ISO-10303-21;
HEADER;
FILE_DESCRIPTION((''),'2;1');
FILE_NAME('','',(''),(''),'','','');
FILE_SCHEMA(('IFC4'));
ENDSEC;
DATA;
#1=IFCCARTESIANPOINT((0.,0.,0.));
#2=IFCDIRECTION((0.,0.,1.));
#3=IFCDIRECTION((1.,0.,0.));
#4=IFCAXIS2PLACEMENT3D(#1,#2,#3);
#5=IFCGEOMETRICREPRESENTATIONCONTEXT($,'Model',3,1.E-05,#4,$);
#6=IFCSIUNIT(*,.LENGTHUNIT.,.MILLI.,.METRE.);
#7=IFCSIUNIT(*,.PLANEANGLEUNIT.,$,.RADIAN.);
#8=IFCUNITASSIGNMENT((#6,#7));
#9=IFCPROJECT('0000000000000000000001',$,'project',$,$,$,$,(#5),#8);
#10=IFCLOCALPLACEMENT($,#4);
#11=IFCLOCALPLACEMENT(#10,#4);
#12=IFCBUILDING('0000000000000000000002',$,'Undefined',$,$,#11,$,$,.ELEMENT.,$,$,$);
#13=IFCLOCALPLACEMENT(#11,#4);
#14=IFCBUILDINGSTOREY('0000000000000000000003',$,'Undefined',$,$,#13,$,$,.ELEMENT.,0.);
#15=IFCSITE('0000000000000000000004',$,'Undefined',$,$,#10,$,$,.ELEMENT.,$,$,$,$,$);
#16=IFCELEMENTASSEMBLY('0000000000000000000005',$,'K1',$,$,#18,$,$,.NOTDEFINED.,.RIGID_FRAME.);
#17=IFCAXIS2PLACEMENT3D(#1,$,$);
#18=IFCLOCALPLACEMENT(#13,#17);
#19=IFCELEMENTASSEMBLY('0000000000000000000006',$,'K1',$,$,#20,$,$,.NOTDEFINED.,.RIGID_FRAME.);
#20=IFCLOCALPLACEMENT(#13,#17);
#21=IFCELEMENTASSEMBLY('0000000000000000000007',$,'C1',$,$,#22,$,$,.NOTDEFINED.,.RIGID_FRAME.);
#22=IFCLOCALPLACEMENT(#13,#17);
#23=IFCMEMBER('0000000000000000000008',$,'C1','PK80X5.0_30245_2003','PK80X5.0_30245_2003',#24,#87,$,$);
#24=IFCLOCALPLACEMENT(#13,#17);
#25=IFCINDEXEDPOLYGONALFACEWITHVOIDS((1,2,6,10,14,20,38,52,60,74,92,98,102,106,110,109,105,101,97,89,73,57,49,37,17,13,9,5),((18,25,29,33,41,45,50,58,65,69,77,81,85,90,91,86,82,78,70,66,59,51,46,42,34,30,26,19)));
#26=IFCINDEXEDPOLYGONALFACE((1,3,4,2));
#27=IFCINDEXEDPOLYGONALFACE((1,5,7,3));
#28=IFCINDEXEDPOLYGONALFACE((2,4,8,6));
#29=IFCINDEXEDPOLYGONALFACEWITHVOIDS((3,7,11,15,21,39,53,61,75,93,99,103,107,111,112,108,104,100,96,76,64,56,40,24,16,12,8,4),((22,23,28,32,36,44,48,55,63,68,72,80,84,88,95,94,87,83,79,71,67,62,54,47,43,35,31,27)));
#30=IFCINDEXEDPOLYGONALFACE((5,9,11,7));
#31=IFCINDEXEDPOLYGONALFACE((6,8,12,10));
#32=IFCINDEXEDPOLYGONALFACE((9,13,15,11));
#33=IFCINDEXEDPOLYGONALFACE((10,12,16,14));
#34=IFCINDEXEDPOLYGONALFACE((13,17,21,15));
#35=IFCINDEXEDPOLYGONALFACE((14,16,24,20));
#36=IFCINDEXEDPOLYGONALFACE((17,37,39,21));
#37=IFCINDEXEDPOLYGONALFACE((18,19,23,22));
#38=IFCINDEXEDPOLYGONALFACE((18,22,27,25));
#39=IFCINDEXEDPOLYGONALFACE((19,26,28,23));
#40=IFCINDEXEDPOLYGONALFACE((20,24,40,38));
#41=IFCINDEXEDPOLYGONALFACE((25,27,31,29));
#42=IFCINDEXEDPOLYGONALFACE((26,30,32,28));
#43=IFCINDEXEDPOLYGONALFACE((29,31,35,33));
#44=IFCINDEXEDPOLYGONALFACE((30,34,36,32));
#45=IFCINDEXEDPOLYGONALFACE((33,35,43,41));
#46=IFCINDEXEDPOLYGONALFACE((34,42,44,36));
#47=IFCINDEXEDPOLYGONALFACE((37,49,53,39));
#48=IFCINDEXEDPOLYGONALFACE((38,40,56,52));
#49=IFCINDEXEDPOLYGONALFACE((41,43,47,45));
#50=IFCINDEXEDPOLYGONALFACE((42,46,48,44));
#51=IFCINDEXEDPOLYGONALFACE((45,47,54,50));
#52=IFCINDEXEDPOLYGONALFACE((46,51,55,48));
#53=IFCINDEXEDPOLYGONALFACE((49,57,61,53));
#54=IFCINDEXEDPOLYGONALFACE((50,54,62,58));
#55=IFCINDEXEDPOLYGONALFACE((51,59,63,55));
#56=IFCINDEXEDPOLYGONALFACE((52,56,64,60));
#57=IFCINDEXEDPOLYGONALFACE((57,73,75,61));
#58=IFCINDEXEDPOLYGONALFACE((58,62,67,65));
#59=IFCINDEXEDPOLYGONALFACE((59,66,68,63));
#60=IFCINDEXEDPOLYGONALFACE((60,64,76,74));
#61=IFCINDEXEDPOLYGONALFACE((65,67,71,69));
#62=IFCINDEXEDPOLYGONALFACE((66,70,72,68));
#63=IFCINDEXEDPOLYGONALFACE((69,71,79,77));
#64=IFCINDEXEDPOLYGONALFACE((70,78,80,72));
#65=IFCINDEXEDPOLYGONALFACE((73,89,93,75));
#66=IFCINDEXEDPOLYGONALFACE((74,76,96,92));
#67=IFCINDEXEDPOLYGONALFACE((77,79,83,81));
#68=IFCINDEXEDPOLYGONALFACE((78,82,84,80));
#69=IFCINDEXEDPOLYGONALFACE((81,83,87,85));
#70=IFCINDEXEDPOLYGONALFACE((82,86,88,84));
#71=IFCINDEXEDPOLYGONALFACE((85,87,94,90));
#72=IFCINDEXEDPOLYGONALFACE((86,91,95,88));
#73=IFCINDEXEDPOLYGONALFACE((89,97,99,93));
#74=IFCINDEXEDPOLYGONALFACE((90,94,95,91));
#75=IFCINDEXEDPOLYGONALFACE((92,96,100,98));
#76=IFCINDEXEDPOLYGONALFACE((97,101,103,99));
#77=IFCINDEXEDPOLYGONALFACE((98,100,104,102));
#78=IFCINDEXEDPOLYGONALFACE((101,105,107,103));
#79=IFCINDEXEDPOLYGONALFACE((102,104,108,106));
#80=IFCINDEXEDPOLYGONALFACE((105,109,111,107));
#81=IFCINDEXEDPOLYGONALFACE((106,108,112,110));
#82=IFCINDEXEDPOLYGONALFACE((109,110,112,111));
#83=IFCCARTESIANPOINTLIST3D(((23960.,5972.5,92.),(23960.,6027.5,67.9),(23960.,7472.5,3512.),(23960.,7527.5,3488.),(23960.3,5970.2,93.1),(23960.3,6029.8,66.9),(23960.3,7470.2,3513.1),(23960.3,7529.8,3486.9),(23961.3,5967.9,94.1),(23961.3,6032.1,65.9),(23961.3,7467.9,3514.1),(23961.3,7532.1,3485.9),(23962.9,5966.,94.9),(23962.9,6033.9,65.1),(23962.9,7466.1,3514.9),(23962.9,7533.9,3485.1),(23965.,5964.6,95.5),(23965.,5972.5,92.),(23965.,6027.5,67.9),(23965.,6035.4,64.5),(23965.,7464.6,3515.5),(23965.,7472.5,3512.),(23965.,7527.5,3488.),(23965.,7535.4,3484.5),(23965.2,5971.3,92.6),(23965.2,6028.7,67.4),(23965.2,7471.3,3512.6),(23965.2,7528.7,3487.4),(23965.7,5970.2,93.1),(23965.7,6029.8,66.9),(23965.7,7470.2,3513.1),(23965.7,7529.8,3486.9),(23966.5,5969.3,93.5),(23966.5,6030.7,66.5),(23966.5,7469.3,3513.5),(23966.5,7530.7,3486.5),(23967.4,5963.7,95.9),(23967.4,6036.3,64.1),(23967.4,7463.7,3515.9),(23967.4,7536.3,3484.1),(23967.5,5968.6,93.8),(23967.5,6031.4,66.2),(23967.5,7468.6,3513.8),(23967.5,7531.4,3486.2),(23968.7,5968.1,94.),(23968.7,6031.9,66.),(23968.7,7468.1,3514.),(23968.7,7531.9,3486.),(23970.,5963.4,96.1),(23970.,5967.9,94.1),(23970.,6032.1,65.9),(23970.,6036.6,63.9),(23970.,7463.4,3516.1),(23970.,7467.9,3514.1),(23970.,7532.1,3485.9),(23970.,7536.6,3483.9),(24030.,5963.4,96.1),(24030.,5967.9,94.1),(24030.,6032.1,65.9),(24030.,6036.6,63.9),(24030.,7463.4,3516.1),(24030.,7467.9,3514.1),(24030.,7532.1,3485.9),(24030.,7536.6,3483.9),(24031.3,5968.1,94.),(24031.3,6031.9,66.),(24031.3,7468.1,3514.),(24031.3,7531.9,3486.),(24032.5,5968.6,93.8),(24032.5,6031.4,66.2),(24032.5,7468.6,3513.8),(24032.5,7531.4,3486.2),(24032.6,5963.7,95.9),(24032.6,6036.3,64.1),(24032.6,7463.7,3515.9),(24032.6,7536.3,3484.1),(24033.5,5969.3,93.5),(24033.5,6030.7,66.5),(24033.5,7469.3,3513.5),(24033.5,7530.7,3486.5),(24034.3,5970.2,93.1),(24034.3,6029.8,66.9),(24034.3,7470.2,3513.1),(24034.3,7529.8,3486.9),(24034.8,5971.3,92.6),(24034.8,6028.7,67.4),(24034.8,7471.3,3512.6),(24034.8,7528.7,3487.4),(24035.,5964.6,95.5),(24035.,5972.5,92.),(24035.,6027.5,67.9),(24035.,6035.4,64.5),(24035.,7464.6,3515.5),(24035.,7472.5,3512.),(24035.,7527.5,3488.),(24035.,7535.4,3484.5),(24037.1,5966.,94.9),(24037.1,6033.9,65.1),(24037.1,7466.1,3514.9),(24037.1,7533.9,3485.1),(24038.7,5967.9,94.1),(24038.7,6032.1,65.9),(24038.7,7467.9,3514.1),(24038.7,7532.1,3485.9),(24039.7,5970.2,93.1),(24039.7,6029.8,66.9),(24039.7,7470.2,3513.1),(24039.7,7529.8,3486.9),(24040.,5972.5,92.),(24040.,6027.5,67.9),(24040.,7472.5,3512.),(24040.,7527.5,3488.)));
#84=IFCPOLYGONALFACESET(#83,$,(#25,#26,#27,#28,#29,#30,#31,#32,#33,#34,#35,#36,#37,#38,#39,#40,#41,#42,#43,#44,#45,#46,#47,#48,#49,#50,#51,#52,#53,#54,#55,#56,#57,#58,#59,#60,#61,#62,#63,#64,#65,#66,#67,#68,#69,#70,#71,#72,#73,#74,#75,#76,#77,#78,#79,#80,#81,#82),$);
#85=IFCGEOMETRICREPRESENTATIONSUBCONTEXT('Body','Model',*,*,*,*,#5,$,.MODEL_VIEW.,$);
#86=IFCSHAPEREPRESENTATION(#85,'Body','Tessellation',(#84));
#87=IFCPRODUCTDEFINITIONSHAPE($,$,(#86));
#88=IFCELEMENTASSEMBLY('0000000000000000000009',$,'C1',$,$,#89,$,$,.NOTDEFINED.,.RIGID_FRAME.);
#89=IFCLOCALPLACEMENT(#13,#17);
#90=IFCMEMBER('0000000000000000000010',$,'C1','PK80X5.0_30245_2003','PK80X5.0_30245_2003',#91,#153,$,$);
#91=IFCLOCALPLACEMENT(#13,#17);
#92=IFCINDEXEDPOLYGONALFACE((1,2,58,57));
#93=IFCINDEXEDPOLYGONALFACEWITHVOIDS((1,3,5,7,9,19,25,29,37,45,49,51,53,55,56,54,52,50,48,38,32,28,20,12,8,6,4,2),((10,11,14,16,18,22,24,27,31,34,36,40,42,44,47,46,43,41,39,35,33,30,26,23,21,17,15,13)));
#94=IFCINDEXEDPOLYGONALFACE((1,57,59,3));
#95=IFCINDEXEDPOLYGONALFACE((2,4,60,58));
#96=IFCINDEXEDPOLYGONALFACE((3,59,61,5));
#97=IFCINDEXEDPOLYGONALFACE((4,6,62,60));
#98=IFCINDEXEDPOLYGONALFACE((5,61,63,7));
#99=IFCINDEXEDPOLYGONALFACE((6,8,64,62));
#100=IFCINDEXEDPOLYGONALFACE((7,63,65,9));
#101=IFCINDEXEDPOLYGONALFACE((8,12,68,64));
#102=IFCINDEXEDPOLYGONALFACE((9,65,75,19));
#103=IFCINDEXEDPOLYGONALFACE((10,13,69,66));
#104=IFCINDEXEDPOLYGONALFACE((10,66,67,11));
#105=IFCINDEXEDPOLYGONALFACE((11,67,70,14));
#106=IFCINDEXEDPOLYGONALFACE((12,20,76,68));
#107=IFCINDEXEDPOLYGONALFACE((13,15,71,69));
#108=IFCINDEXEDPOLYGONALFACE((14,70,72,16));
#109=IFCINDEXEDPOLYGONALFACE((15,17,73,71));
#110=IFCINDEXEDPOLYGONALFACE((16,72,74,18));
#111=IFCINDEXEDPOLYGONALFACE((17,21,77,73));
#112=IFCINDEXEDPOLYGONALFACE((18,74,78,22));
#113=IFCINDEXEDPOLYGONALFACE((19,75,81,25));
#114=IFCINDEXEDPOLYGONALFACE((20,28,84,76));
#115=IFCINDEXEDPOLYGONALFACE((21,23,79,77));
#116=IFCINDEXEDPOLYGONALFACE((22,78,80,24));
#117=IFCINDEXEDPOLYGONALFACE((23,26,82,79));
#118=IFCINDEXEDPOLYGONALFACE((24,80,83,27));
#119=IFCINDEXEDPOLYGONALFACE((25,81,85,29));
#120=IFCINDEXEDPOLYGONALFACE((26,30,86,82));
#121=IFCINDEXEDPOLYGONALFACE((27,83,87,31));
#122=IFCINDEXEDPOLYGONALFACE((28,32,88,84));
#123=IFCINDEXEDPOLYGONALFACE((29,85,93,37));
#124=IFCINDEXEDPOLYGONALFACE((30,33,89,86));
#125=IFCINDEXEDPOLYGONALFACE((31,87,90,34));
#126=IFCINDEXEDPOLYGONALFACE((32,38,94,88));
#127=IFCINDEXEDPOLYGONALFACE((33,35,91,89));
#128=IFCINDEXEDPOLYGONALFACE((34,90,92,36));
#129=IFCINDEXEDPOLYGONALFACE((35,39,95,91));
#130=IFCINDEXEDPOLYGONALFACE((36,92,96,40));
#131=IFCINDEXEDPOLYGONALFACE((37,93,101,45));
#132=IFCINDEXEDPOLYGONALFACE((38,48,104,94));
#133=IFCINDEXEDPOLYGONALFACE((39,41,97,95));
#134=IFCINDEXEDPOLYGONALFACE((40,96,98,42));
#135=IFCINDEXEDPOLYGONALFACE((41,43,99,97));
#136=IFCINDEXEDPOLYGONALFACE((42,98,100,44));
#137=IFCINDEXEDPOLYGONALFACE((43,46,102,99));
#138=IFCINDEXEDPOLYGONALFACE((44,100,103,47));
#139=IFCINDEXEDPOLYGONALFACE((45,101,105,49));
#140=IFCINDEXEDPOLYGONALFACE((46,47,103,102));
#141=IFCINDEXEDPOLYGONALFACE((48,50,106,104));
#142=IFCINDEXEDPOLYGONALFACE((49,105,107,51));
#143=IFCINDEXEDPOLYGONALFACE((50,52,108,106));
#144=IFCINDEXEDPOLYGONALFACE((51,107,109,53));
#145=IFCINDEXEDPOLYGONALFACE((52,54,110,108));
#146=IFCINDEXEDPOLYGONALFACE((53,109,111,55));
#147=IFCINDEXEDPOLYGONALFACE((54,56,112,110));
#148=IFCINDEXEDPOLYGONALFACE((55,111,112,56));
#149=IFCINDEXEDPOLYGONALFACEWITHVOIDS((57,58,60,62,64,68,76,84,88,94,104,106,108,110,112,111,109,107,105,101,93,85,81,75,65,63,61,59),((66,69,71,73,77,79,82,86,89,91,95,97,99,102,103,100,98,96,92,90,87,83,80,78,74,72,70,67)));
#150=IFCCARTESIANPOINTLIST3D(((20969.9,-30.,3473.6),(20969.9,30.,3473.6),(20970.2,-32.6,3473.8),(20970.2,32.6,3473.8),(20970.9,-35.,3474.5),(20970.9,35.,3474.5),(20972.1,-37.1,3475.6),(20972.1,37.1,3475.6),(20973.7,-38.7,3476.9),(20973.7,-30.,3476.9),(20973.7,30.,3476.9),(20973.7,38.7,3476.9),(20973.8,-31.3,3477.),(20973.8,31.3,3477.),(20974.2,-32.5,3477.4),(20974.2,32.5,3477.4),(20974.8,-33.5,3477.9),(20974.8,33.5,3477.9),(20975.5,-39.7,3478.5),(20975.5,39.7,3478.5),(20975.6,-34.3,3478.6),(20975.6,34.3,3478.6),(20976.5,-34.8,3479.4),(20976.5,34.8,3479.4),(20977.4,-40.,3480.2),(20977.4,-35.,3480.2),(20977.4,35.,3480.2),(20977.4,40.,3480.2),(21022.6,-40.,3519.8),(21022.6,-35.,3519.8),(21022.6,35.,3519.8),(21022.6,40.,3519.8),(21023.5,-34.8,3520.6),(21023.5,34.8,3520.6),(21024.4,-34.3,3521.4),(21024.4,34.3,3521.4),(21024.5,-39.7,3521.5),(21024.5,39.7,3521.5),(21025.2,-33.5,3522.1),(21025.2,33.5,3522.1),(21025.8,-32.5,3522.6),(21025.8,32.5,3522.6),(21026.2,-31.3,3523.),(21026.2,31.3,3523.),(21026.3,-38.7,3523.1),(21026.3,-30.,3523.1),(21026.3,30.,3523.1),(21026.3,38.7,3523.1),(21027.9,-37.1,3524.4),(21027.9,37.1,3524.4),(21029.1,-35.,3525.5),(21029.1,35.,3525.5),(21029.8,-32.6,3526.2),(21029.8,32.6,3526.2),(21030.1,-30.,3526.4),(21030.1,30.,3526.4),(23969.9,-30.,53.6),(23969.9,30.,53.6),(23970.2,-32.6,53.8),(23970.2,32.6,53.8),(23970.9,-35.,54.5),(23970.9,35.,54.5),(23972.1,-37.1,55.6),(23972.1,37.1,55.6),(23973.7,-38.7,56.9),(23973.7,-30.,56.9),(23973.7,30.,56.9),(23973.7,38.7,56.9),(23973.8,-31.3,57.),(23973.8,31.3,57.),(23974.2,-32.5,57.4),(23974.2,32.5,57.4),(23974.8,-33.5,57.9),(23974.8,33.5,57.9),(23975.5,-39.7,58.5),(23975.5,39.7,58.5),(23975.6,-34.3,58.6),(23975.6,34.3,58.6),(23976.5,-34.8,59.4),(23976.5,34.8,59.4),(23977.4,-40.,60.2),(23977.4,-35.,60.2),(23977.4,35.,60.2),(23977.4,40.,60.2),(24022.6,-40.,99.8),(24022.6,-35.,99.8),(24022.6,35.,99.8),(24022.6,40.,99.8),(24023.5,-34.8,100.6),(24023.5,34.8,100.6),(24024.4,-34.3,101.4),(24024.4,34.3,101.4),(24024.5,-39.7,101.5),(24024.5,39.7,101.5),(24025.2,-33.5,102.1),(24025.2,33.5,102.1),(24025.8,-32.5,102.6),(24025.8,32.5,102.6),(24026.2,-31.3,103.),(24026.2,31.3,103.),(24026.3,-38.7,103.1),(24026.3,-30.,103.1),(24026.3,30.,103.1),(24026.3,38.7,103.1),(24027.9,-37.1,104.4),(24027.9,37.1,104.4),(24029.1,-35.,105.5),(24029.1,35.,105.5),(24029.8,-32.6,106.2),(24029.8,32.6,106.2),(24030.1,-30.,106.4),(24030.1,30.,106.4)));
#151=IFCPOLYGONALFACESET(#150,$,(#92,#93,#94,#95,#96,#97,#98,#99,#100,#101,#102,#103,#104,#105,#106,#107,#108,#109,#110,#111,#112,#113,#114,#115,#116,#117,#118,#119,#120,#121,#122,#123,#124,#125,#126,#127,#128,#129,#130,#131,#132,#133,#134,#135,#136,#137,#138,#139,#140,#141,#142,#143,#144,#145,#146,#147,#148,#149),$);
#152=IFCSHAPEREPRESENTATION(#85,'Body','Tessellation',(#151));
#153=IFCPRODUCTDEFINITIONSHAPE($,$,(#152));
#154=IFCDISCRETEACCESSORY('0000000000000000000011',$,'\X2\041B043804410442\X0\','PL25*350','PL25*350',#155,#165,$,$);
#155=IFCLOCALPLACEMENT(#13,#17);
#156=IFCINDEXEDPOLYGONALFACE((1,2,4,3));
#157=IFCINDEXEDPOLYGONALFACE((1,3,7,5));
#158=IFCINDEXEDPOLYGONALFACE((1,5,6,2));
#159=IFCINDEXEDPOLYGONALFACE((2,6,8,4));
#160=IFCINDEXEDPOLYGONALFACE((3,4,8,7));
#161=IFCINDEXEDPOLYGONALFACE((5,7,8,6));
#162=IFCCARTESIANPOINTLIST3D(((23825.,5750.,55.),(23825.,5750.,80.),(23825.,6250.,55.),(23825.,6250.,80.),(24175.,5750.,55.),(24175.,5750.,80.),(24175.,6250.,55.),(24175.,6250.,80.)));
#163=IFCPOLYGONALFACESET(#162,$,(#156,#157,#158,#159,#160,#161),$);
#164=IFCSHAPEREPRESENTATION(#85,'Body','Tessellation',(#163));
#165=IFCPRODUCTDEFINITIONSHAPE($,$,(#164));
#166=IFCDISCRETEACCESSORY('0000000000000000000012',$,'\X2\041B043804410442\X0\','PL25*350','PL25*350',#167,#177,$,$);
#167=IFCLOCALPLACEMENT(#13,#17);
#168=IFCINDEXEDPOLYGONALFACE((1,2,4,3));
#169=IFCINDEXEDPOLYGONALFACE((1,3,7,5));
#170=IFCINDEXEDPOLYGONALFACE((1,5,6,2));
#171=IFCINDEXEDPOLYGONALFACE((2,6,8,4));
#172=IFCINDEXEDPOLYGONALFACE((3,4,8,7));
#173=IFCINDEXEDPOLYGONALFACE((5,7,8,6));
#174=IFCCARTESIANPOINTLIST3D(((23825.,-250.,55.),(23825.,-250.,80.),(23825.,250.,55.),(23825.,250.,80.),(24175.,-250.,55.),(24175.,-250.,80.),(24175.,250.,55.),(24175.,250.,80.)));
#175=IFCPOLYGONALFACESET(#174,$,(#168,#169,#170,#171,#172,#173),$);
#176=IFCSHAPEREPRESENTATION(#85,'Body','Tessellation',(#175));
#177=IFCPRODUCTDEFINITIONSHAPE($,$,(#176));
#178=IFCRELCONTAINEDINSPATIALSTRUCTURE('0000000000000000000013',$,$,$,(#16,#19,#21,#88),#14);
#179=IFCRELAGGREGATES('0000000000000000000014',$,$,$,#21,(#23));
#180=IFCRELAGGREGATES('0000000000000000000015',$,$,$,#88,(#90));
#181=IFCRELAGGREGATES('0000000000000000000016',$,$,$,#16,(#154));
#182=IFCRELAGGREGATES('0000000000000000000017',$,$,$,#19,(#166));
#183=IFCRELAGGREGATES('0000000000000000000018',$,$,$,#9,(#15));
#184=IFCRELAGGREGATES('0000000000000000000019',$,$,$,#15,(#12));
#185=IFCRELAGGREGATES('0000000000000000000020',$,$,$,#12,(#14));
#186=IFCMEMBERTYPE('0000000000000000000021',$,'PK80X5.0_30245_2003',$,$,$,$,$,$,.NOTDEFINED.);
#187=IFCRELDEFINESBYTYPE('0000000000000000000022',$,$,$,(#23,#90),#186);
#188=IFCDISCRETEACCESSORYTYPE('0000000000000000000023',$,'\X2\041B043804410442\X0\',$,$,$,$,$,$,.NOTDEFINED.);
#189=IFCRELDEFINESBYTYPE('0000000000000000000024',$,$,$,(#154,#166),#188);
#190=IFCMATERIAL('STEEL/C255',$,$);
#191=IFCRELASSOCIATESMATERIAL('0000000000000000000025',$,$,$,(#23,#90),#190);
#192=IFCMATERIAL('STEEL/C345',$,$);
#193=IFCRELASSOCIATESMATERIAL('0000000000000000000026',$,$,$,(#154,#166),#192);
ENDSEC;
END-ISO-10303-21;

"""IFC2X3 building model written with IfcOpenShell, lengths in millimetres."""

from ifc_helpers import new_model, si_unit, frame, origin_with_axes, origin_2d_with_axis, place, context, subcontext, project, spatial, polyline, hollow_rectangle, outline, extrude, material, type_object, element, aggregate, save


model = new_model("IFC2X3")

# Units and contexts
model_context = context("Model", 3, precision=1e-05, world=origin_with_axes())
body_context = subcontext(model_context, "Body", "Model", "MODEL_VIEW")
ifc_project = project(units=[si_unit("LENGTHUNIT", "METRE", prefix="MILLI"), si_unit("PLANEANGLEUNIT", "RADIAN")], contexts=[model_context])

# Site, building, storey
site_placement = place(None, origin_with_axes())
site = spatial("IfcSite", under=ifc_project, at=site_placement, Name="Undefined", CompositionType="ELEMENT")
building_placement = place(site_placement, origin_with_axes())
building = spatial("IfcBuilding", under=site, at=building_placement, Name="Undefined", CompositionType="ELEMENT")
storey_placement = place(building_placement, origin_with_axes())
storey = spatial("IfcBuildingStorey", under=building, at=storey_placement, Name="Undefined", CompositionType="ELEMENT", Elevation=0.0)

# Element assemblies
assembly_1_placement = place(storey_placement, origin_with_axes())
assembly_1 = element("IfcElementAssembly", 1, at=assembly_1_placement, inside=storey, Name="K1", AssemblyPlace="NOTDEFINED", PredefinedType="RIGID_FRAME")
ifc_material_1 = material(Name="STEEL/C345")
assembly_2_placement = place(storey_placement, origin_with_axes())
assembly_2 = element("IfcElementAssembly", 2, at=assembly_2_placement, inside=storey, Name="K1", AssemblyPlace="NOTDEFINED", PredefinedType="RIGID_FRAME")

# Shared definitions
ifc_material_2 = material(Name="STEEL/C255")

# Element assemblies, members
assembly_3_placement = place(storey_placement, origin_with_axes())
assembly_3 = element("IfcElementAssembly", 3, at=assembly_3_placement, inside=storey, Name="C1", AssemblyPlace="NOTDEFINED", PredefinedType="RIGID_FRAME")
member_type = type_object("IfcMemberType", Name="PK80X5.0_30245_2003", PredefinedType="NOTDEFINED")
member_1_placement = place(assembly_3_placement, frame((24000.0, 6000.0, 80.0), z_axis=(0.0, 0.915788, -0.401661), x_axis=(0.0, 0.401661, 0.915788)))
member_1 = element("IfcMember", 4, at=member_1_placement, type_object=member_type, material=ifc_material_2, Name="C1", Description="PK80X5.0_30245_2003", ObjectType="PK80X5.0_30245_2003", context=body_context, shape_type="SweptSolid", body=[
    extrude(hollow_rectangle(XDim=80.0, YDim=80.0, WallThickness=5.0, InnerFilletRadius=5.0, OuterFilletRadius=10.0, at=origin_2d_with_axis()), frame((3734.5, 0.0, 0.0), z_axis=(-1.0, 0.0, 0.0), x_axis=(0.0, -1.0, 0.0)), (0.0, 0.0, 1.0), 3734.5),
])
aggregate(assembly_3, [member_1])
assembly_4_placement = place(storey_placement, origin_with_axes())
assembly_4 = element("IfcElementAssembly", 5, at=assembly_4_placement, inside=storey, Name="C1", AssemblyPlace="NOTDEFINED", PredefinedType="RIGID_FRAME")
member_2_placement = place(assembly_4_placement, frame((24000.0, 0.0, 80.0), z_axis=(-0.751759, 0.0, -0.659438), x_axis=(-0.659438, 0.0, 0.751759)))
member_2 = element("IfcMember", 6, at=member_2_placement, type_object=member_type, material=ifc_material_2, Name="C1", Description="PK80X5.0_30245_2003", ObjectType="PK80X5.0_30245_2003", context=body_context, shape_type="SweptSolid", body=[
    extrude(hollow_rectangle(XDim=80.0, YDim=80.0, WallThickness=5.0, InnerFilletRadius=5.0, OuterFilletRadius=10.0, at=origin_2d_with_axis()), frame((4549.3, 0.0, 0.0), z_axis=(-1.0, 0.0, 0.0), x_axis=(0.0, -1.0, 0.0)), (0.0, 0.0, 1.0), 4549.3),
])
aggregate(assembly_4, [member_2])

# Discrete accessories
discrete_accessory_type = type_object("IfcDiscreteAccessoryType", Name="Лист")
discrete_accessory_1_placement = place(assembly_1_placement, frame((23825.0, 6250.0, 67.5), z_axis=(0.0, 0.0, 1.0), x_axis=(0.0, -1.0, 0.0)))
discrete_accessory_1 = element("IfcDiscreteAccessory", 7, at=discrete_accessory_1_placement, type_object=discrete_accessory_type, material=ifc_material_1, Name="Лист", Description="PL25*350", ObjectType="PL25*350", context=body_context, shape_type="SweptSolid", body=[
    extrude(outline(polyline([(0.0, 0.0), (500.0, 0.0), (500.0, 350.0), (0.0, 350.0), (0.0, 0.0)])), frame((0.0, 0.0, -12.5), z_axis=(0.0, 0.0, 1.0), x_axis=(1.0, 0.0, 0.0)), (0.0, 0.0, 1.0), 25.0),
])
aggregate(assembly_1, [discrete_accessory_1])
discrete_accessory_2_placement = place(assembly_2_placement, frame((23825.0, 250.0, 67.5), z_axis=(0.0, 0.0, 1.0), x_axis=(0.0, -1.0, 0.0)))
discrete_accessory_2 = element("IfcDiscreteAccessory", 8, at=discrete_accessory_2_placement, type_object=discrete_accessory_type, material=ifc_material_1, Name="Лист", Description="PL25*350", ObjectType="PL25*350", context=body_context, shape_type="SweptSolid", body=[
    extrude(outline(polyline([(0.0, 0.0), (500.0, 0.0), (500.0, 350.0), (0.0, 350.0), (0.0, 0.0)])), frame((0.0, 0.0, -12.5), z_axis=(0.0, 0.0, 1.0), x_axis=(1.0, 0.0, 0.0)), (0.0, 0.0, 1.0), 25.0),
])
aggregate(assembly_2, [discrete_accessory_2])

save(model, "model.ifc")
